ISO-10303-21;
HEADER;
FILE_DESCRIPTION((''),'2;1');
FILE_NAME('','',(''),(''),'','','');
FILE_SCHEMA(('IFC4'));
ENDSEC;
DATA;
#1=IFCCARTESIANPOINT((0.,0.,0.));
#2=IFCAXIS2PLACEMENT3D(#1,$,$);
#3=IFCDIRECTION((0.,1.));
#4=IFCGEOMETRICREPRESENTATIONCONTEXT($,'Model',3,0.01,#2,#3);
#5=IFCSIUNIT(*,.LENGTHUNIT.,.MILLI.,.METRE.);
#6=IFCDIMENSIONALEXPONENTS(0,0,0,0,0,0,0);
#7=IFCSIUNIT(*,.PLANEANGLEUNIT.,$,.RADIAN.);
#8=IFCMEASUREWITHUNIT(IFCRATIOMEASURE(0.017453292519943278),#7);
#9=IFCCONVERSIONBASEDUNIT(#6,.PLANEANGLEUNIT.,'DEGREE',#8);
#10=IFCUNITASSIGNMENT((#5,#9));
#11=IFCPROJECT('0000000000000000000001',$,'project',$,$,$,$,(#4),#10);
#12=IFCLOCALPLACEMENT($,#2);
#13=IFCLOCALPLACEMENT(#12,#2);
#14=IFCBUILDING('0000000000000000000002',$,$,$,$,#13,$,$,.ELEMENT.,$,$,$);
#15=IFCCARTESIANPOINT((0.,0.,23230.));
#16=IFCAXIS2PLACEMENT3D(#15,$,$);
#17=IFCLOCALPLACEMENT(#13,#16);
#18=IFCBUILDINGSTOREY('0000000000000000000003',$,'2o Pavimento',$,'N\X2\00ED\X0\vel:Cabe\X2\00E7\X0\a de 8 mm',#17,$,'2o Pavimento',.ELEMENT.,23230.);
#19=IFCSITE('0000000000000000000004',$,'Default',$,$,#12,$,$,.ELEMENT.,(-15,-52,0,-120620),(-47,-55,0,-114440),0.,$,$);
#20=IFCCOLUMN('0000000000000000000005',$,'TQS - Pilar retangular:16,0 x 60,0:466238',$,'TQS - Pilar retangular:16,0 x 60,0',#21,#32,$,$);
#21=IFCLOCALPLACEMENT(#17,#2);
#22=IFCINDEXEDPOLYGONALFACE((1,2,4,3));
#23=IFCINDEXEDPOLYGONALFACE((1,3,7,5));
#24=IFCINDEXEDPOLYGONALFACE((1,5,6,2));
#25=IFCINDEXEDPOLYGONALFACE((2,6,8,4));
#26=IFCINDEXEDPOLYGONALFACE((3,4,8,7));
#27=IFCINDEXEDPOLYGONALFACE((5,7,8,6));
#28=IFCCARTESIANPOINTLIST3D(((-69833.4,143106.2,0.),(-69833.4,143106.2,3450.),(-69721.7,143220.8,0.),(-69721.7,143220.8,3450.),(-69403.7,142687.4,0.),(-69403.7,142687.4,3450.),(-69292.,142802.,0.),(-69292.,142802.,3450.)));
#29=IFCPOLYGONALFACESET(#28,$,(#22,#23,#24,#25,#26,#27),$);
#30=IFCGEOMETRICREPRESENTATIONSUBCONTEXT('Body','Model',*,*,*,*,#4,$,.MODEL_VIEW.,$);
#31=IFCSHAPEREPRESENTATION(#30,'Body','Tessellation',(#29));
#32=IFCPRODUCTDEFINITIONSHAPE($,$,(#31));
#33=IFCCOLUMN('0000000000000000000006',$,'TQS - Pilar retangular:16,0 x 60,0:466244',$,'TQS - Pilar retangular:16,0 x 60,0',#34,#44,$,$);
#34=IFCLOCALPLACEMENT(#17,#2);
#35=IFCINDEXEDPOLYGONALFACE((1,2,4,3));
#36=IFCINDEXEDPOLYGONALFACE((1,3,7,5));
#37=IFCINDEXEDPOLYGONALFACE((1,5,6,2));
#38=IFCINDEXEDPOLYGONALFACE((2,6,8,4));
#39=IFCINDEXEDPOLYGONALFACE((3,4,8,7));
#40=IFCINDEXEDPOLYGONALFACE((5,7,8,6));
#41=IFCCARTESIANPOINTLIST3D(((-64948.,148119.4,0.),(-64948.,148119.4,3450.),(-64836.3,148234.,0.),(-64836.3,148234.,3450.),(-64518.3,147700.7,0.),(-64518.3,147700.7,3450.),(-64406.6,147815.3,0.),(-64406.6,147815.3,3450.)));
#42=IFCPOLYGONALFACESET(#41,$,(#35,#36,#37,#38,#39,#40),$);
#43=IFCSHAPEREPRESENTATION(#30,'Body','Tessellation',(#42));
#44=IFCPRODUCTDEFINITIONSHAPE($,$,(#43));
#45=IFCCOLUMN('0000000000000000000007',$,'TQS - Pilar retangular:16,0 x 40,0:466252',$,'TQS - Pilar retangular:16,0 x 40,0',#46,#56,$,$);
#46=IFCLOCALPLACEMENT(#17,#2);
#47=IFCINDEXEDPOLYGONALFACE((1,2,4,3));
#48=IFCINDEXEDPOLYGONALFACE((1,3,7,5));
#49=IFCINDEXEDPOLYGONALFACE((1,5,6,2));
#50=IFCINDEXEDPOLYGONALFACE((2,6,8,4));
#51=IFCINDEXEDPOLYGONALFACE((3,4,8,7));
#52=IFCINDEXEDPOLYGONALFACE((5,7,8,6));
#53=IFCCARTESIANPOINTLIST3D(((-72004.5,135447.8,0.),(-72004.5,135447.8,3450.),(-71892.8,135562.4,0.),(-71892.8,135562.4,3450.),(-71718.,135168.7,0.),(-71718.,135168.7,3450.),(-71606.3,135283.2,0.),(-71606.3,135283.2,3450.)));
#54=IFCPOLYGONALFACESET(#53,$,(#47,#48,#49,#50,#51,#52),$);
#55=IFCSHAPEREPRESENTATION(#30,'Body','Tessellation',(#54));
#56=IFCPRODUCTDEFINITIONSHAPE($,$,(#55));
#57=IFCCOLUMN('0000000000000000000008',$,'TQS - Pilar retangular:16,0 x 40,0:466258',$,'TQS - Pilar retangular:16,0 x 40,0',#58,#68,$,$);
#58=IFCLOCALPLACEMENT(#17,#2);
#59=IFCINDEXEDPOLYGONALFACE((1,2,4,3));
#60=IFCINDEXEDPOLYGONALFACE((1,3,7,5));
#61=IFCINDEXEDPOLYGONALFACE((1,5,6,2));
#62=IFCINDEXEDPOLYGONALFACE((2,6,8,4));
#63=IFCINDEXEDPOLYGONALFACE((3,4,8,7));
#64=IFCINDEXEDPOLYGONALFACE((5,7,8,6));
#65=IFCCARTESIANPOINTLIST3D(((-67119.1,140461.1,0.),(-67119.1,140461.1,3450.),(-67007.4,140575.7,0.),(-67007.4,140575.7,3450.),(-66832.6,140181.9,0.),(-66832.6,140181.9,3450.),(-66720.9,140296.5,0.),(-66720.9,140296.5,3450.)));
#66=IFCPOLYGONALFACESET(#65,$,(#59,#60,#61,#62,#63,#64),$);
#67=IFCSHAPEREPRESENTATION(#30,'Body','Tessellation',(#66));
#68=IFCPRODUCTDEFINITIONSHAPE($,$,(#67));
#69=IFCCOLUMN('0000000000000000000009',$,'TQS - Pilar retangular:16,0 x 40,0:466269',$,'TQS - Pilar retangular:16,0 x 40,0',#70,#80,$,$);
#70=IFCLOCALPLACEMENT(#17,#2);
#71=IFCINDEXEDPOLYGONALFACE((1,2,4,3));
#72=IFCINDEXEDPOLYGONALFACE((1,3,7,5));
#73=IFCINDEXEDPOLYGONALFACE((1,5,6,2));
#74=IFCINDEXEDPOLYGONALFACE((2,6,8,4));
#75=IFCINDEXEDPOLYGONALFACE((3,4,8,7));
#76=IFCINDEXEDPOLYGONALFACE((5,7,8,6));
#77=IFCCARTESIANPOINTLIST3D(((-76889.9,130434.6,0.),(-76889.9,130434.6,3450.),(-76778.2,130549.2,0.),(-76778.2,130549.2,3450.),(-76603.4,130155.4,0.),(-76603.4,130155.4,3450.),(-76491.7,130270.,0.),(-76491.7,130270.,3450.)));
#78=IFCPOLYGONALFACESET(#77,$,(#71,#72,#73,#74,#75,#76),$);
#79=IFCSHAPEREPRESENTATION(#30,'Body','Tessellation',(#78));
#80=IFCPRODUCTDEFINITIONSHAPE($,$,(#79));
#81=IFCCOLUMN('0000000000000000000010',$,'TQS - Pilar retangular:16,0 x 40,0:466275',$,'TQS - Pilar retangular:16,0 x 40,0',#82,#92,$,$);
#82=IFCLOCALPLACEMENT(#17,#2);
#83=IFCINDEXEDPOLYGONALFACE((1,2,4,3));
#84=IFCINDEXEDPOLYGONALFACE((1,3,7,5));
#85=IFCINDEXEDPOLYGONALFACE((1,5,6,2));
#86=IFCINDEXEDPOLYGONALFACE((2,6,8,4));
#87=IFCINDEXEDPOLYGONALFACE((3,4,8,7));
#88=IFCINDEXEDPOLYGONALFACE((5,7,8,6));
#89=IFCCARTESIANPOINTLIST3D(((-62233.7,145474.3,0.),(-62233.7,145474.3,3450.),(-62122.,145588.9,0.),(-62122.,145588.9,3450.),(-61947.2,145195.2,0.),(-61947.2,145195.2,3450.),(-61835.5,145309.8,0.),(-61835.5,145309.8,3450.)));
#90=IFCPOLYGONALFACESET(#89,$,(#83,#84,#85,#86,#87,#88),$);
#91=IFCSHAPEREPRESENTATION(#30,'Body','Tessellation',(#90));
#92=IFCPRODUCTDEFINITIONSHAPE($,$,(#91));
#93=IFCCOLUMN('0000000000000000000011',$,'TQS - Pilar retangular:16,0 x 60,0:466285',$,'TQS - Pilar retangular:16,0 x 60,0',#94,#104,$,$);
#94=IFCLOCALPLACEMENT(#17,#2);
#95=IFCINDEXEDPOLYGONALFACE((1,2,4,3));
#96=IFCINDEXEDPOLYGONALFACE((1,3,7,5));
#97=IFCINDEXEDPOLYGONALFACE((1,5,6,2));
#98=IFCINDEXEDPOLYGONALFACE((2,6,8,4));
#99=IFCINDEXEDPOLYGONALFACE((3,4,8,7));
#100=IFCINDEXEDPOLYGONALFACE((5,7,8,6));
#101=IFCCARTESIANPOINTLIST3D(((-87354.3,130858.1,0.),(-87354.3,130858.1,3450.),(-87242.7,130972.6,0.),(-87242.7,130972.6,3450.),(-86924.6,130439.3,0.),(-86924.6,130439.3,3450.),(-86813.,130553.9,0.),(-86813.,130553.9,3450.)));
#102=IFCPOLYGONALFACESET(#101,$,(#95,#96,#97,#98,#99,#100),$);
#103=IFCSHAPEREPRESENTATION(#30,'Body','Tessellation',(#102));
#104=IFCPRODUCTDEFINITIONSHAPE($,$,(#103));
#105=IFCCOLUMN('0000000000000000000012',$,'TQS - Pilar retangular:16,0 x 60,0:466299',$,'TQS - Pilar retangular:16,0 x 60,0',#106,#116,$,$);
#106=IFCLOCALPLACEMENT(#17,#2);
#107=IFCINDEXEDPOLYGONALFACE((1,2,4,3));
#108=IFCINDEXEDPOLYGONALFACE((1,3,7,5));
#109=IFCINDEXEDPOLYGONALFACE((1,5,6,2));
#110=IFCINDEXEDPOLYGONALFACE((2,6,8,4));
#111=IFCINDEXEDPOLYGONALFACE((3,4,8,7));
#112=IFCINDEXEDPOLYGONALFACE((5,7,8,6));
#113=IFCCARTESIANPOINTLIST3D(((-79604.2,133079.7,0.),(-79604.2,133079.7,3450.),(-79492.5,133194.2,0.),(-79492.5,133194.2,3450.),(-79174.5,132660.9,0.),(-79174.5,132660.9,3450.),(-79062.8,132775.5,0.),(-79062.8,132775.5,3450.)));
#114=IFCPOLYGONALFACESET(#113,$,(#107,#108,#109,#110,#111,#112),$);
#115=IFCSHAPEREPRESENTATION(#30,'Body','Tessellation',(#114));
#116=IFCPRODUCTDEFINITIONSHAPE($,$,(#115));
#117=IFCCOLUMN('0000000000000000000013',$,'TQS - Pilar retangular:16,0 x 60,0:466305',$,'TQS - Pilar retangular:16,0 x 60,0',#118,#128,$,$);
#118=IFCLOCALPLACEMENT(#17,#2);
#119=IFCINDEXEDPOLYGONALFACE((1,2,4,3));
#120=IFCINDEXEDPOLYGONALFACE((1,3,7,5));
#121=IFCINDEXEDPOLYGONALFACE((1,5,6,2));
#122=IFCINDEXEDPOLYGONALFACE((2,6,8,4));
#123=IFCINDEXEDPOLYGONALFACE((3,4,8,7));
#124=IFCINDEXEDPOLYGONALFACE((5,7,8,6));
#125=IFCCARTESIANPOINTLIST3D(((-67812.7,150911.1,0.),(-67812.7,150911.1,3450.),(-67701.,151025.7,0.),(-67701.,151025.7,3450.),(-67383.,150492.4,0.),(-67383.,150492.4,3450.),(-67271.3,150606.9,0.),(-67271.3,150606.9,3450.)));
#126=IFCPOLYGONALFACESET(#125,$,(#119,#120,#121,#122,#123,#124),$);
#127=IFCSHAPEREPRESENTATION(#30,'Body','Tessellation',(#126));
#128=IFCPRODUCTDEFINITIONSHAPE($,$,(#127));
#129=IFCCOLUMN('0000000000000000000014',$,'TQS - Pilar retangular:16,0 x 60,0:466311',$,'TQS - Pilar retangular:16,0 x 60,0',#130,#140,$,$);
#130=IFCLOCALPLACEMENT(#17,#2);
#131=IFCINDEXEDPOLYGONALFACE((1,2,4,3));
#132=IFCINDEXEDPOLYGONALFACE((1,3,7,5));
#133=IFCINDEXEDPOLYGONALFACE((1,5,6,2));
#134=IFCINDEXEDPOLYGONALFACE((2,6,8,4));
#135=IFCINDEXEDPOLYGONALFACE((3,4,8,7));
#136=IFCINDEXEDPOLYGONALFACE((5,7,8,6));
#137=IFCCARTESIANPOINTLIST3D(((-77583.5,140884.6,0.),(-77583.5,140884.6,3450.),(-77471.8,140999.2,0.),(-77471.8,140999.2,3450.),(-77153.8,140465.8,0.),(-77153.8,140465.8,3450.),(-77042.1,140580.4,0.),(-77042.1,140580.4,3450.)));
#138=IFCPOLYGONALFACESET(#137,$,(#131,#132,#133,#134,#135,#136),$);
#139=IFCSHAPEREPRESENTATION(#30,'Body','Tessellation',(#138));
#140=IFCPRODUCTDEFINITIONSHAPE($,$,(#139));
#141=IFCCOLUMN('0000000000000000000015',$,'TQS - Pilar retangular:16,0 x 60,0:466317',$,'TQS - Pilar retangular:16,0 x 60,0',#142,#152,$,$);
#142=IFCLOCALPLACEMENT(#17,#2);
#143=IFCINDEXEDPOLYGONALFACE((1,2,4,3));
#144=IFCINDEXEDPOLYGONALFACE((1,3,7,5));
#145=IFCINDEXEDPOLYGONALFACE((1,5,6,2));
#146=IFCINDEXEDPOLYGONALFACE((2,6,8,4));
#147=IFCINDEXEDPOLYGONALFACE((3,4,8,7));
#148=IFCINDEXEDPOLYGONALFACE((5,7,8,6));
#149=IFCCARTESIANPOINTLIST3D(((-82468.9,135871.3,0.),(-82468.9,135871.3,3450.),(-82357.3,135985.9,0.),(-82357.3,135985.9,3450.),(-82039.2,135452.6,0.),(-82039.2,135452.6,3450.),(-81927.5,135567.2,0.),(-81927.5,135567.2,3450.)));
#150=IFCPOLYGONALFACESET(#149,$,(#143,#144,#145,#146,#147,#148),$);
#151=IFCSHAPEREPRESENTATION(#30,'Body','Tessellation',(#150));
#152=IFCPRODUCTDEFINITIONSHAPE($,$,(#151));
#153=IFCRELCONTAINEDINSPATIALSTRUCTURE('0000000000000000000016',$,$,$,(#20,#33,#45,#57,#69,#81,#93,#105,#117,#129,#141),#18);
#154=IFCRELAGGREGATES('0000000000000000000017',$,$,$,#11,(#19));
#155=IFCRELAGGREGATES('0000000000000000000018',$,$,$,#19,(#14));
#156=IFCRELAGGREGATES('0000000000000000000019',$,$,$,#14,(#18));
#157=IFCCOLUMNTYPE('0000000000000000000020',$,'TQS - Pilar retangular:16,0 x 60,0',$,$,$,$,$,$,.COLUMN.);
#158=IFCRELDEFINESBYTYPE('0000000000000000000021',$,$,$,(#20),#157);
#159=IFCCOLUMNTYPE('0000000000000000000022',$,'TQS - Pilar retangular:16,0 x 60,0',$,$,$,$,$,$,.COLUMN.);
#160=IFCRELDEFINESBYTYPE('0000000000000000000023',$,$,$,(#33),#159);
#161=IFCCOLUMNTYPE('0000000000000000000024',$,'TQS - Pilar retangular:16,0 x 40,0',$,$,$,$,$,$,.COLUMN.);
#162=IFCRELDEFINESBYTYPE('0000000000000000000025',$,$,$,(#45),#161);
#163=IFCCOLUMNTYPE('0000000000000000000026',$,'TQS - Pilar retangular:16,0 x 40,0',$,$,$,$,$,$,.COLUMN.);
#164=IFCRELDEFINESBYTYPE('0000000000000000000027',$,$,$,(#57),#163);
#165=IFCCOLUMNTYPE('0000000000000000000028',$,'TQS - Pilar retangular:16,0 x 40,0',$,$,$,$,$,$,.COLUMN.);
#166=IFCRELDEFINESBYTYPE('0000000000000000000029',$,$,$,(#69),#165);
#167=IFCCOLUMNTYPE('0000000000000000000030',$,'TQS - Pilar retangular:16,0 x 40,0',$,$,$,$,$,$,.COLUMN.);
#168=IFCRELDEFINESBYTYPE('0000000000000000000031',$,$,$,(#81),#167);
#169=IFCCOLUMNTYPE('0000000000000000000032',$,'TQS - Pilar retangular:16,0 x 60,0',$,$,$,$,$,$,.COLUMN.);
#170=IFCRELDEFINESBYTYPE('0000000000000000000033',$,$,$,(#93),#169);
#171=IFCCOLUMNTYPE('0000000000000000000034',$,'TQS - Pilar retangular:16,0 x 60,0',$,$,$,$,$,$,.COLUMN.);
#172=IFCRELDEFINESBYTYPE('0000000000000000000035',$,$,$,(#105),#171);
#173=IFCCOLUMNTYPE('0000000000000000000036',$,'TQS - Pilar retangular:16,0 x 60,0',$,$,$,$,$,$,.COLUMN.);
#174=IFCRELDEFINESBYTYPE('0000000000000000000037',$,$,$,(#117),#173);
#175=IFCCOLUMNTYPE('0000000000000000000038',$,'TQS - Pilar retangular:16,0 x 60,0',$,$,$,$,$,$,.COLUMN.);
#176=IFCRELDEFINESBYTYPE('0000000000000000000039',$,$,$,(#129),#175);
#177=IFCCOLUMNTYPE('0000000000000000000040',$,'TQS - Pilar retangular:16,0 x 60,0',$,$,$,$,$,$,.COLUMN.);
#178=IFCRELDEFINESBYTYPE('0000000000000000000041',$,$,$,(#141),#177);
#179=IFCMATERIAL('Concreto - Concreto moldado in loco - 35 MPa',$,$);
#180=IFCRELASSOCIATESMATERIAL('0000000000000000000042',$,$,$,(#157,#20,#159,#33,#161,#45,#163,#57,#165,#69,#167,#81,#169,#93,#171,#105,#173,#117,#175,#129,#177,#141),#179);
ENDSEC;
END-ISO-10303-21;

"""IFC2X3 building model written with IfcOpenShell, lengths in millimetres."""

from ifc_helpers import new_model, entity, si_unit, converted_unit, direction, frame, frame_2d, origin, place, context, subcontext, project, spatial, rectangle, extrude, source, transform, mapped, material, type_object, type_shapes, element, save


model = new_model("IFC2X3")

# Units and contexts
model_context = context("Model", 3, precision=0.01, world=origin(), true_north=direction((0.0, 1.0)))
body_context = subcontext(model_context, "Body", "Model", "MODEL_VIEW")
ifc_project = project(units=[si_unit("LENGTHUNIT", "METRE", prefix="MILLI"), converted_unit("PLANEANGLEUNIT", "DEGREE", entity("IfcRatioMeasure", 0.017453292519943278), si_unit("PLANEANGLEUNIT", "RADIAN"), dimensions=[0, 0, 0, 0, 0, 0, 0])], contexts=[model_context])

# Site, building, storey
site_placement = place(None, origin())
site = spatial("IfcSite", under=ifc_project, at=site_placement, Name="Default", CompositionType="ELEMENT", RefLatitude=(-15, -52, 0, -120620), RefLongitude=(-47, -55, 0, -114440), RefElevation=0.0)
building_placement = place(site_placement, origin())
building = spatial("IfcBuilding", under=site, at=building_placement, CompositionType="ELEMENT")
storey_placement = place(building_placement, frame((0.0, 0.0, 23230.0)))
storey = spatial("IfcBuildingStorey", under=building, at=storey_placement, Name="2o Pavimento", ObjectType="Nível:Cabeça de 8 mm", LongName="2o Pavimento", CompositionType="ELEMENT", Elevation=23230.0)

# Columns
ifc_material = material(Name="Concreto - Concreto moldado in loco - 35 MPa")
column_type_1 = type_object("IfcColumnType", Name="TQS - Pilar retangular:16,0 x 60,0", PredefinedType="COLUMN", material=ifc_material)
shared_shape_1 = source(origin(), body_context, "Body", "SweptSolid", [
    extrude(rectangle(XDim=600.0, YDim=160.0, at=frame_2d((0.0, 0.0), x_axis=(1.0, 0.0))), frame((-69562.7, 142954.1, 23230.0), z_axis=(0.0, 0.0, 1.0), x_axis=(-0.71618, 0.697915, 0.0)), (0.0, 0.0, 1.0), 3450.0),
])
type_shapes(column_type_1, [shared_shape_1])
column_1_placement = place(storey_placement, frame((0.0, 0.0, -23230.0)))
element("IfcColumn", 1, at=column_1_placement, inside=storey, type_object=column_type_1, material=ifc_material, Name="TQS - Pilar retangular:16,0 x 60,0:466238", ObjectType="TQS - Pilar retangular:16,0 x 60,0", context=body_context, shape_type="MappedRepresentation", body=[
    mapped(shared_shape_1, transform((0.0, 0.0, 0.0), scale=1.0)),
])
column_type_2 = type_object("IfcColumnType", Name="TQS - Pilar retangular:16,0 x 60,0", PredefinedType="COLUMN", material=ifc_material)
shared_shape_2 = source(origin(), body_context, "Body", "SweptSolid", [
    extrude(rectangle(XDim=600.0, YDim=160.0, at=frame_2d((0.0, 0.0), x_axis=(1.0, 0.0))), frame((-64677.3, 147967.4, 23230.0), z_axis=(0.0, 0.0, 1.0), x_axis=(-0.71618, 0.697915, 0.0)), (0.0, 0.0, 1.0), 3450.0),
])
type_shapes(column_type_2, [shared_shape_2])
column_2_placement = place(storey_placement, frame((0.0, 0.0, -23230.0)))
element("IfcColumn", 2, at=column_2_placement, inside=storey, type_object=column_type_2, material=ifc_material, Name="TQS - Pilar retangular:16,0 x 60,0:466244", ObjectType="TQS - Pilar retangular:16,0 x 60,0", context=body_context, shape_type="MappedRepresentation", body=[
    mapped(shared_shape_2, transform((0.0, 0.0, 0.0), scale=1.0)),
])
column_type_3 = type_object("IfcColumnType", Name="TQS - Pilar retangular:16,0 x 40,0", PredefinedType="COLUMN", material=ifc_material)
shared_shape_3 = source(origin(), body_context, "Body", "SweptSolid", [
    extrude(rectangle(XDim=400.0, YDim=160.0, at=frame_2d((0.0, 0.0), x_axis=(1.0, 0.0))), frame((-71805.4, 135365.5, 23230.0), z_axis=(0.0, 0.0, 1.0), x_axis=(-0.71618, 0.697915, 0.0)), (0.0, 0.0, 1.0), 3450.0),
])
type_shapes(column_type_3, [shared_shape_3])
column_3_placement = place(storey_placement, frame((0.0, 0.0, -23230.0)))
element("IfcColumn", 3, at=column_3_placement, inside=storey, type_object=column_type_3, material=ifc_material, Name="TQS - Pilar retangular:16,0 x 40,0:466252", ObjectType="TQS - Pilar retangular:16,0 x 40,0", context=body_context, shape_type="MappedRepresentation", body=[
    mapped(shared_shape_3, transform((0.0, 0.0, 0.0), scale=1.0)),
])
column_type_4 = type_object("IfcColumnType", Name="TQS - Pilar retangular:16,0 x 40,0", PredefinedType="COLUMN", material=ifc_material)
shared_shape_4 = source(origin(), body_context, "Body", "SweptSolid", [
    extrude(rectangle(XDim=400.0, YDim=160.0, at=frame_2d((0.0, 0.0), x_axis=(1.0, 0.0))), frame((-66920.0, 140378.8, 23230.0), z_axis=(0.0, 0.0, 1.0), x_axis=(-0.71618, 0.697915, 0.0)), (0.0, 0.0, 1.0), 3450.0),
])
type_shapes(column_type_4, [shared_shape_4])
column_4_placement = place(storey_placement, frame((0.0, 0.0, -23230.0)))
element("IfcColumn", 4, at=column_4_placement, inside=storey, type_object=column_type_4, material=ifc_material, Name="TQS - Pilar retangular:16,0 x 40,0:466258", ObjectType="TQS - Pilar retangular:16,0 x 40,0", context=body_context, shape_type="MappedRepresentation", body=[
    mapped(shared_shape_4, transform((0.0, 0.0, 0.0), scale=1.0)),
])
column_type_5 = type_object("IfcColumnType", Name="TQS - Pilar retangular:16,0 x 40,0", PredefinedType="COLUMN", material=ifc_material)
shared_shape_5 = source(origin(), body_context, "Body", "SweptSolid", [
    extrude(rectangle(XDim=400.0, YDim=160.0, at=frame_2d((0.0, 0.0), x_axis=(1.0, 0.0))), frame((-76690.8, 130352.3, 23230.0), z_axis=(0.0, 0.0, 1.0), x_axis=(-0.71618, 0.697915, 0.0)), (0.0, 0.0, 1.0), 3450.0),
])
type_shapes(column_type_5, [shared_shape_5])
column_5_placement = place(storey_placement, frame((0.0, 0.0, -23230.0)))
element("IfcColumn", 5, at=column_5_placement, inside=storey, type_object=column_type_5, material=ifc_material, Name="TQS - Pilar retangular:16,0 x 40,0:466269", ObjectType="TQS - Pilar retangular:16,0 x 40,0", context=body_context, shape_type="MappedRepresentation", body=[
    mapped(shared_shape_5, transform((0.0, 0.0, 0.0), scale=1.0)),
])
column_type_6 = type_object("IfcColumnType", Name="TQS - Pilar retangular:16,0 x 40,0", PredefinedType="COLUMN", material=ifc_material)
shared_shape_6 = source(origin(), body_context, "Body", "SweptSolid", [
    extrude(rectangle(XDim=400.0, YDim=160.0, at=frame_2d((0.0, 0.0), x_axis=(1.0, 0.0))), frame((-62034.6, 145392.1, 23230.0), z_axis=(0.0, 0.0, 1.0), x_axis=(-0.71618, 0.697915, 0.0)), (0.0, 0.0, 1.0), 3450.0),
])
type_shapes(column_type_6, [shared_shape_6])
column_6_placement = place(storey_placement, frame((0.0, 0.0, -23230.0)))
element("IfcColumn", 6, at=column_6_placement, inside=storey, type_object=column_type_6, material=ifc_material, Name="TQS - Pilar retangular:16,0 x 40,0:466275", ObjectType="TQS - Pilar retangular:16,0 x 40,0", context=body_context, shape_type="MappedRepresentation", body=[
    mapped(shared_shape_6, transform((0.0, 0.0, 0.0), scale=1.0)),
])
column_type_7 = type_object("IfcColumnType", Name="TQS - Pilar retangular:16,0 x 60,0", PredefinedType="COLUMN", material=ifc_material)
shared_shape_7 = source(origin(), body_context, "Body", "SweptSolid", [
    extrude(rectangle(XDim=600.0, YDim=160.0, at=frame_2d((0.0, 0.0), x_axis=(1.0, 0.0))), frame((-87083.6, 130706.0, 23230.0), z_axis=(0.0, 0.0, 1.0), x_axis=(-0.71618, 0.697915, 0.0)), (0.0, 0.0, 1.0), 3450.0),
])
type_shapes(column_type_7, [shared_shape_7])
column_7_placement = place(storey_placement, frame((0.0, 0.0, -23230.0)))
element("IfcColumn", 7, at=column_7_placement, inside=storey, type_object=column_type_7, material=ifc_material, Name="TQS - Pilar retangular:16,0 x 60,0:466285", ObjectType="TQS - Pilar retangular:16,0 x 60,0", context=body_context, shape_type="MappedRepresentation", body=[
    mapped(shared_shape_7, transform((0.0, 0.0, 0.0), scale=1.0)),
])
column_type_8 = type_object("IfcColumnType", Name="TQS - Pilar retangular:16,0 x 60,0", PredefinedType="COLUMN", material=ifc_material)
shared_shape_8 = source(origin(), body_context, "Body", "SweptSolid", [
    extrude(rectangle(XDim=600.0, YDim=160.0, at=frame_2d((0.0, 0.0), x_axis=(1.0, 0.0))), frame((-79333.5, 132927.6, 23230.0), z_axis=(0.0, 0.0, 1.0), x_axis=(-0.71618, 0.697915, 0.0)), (0.0, 0.0, 1.0), 3450.0),
])
type_shapes(column_type_8, [shared_shape_8])
column_8_placement = place(storey_placement, frame((0.0, 0.0, -23230.0)))
element("IfcColumn", 8, at=column_8_placement, inside=storey, type_object=column_type_8, material=ifc_material, Name="TQS - Pilar retangular:16,0 x 60,0:466299", ObjectType="TQS - Pilar retangular:16,0 x 60,0", context=body_context, shape_type="MappedRepresentation", body=[
    mapped(shared_shape_8, transform((0.0, 0.0, 0.0), scale=1.0)),
])
column_type_9 = type_object("IfcColumnType", Name="TQS - Pilar retangular:16,0 x 60,0", PredefinedType="COLUMN", material=ifc_material)
shared_shape_9 = source(origin(), body_context, "Body", "SweptSolid", [
    extrude(rectangle(XDim=600.0, YDim=160.0, at=frame_2d((0.0, 0.0), x_axis=(1.0, 0.0))), frame((-67542.0, 150759.0, 23230.0), z_axis=(0.0, 0.0, 1.0), x_axis=(-0.71618, 0.697915, 0.0)), (0.0, 0.0, 1.0), 3450.0),
])
type_shapes(column_type_9, [shared_shape_9])
column_9_placement = place(storey_placement, frame((0.0, 0.0, -23230.0)))
element("IfcColumn", 9, at=column_9_placement, inside=storey, type_object=column_type_9, material=ifc_material, Name="TQS - Pilar retangular:16,0 x 60,0:466305", ObjectType="TQS - Pilar retangular:16,0 x 60,0", context=body_context, shape_type="MappedRepresentation", body=[
    mapped(shared_shape_9, transform((0.0, 0.0, 0.0), scale=1.0)),
])
column_type_10 = type_object("IfcColumnType", Name="TQS - Pilar retangular:16,0 x 60,0", PredefinedType="COLUMN", material=ifc_material)
shared_shape_10 = source(origin(), body_context, "Body", "SweptSolid", [
    extrude(rectangle(XDim=600.0, YDim=160.0, at=frame_2d((0.0, 0.0), x_axis=(1.0, 0.0))), frame((-77312.8, 140732.5, 23230.0), z_axis=(0.0, 0.0, 1.0), x_axis=(-0.71618, 0.697915, 0.0)), (0.0, 0.0, 1.0), 3450.0),
])
type_shapes(column_type_10, [shared_shape_10])
column_10_placement = place(storey_placement, frame((0.0, 0.0, -23230.0)))
element("IfcColumn", 10, at=column_10_placement, inside=storey, type_object=column_type_10, material=ifc_material, Name="TQS - Pilar retangular:16,0 x 60,0:466311", ObjectType="TQS - Pilar retangular:16,0 x 60,0", context=body_context, shape_type="MappedRepresentation", body=[
    mapped(shared_shape_10, transform((0.0, 0.0, 0.0), scale=1.0)),
])
column_type_11 = type_object("IfcColumnType", Name="TQS - Pilar retangular:16,0 x 60,0", PredefinedType="COLUMN", material=ifc_material)
shared_shape_11 = source(origin(), body_context, "Body", "SweptSolid", [
    extrude(rectangle(XDim=600.0, YDim=160.0, at=frame_2d((0.0, 0.0), x_axis=(1.0, 0.0))), frame((-82198.2, 135719.2, 23230.0), z_axis=(0.0, 0.0, 1.0), x_axis=(-0.71618, 0.697915, 0.0)), (0.0, 0.0, 1.0), 3450.0),
])
type_shapes(column_type_11, [shared_shape_11])
column_11_placement = place(storey_placement, frame((0.0, 0.0, -23230.0)))
element("IfcColumn", 11, at=column_11_placement, inside=storey, type_object=column_type_11, material=ifc_material, Name="TQS - Pilar retangular:16,0 x 60,0:466317", ObjectType="TQS - Pilar retangular:16,0 x 60,0", context=body_context, shape_type="MappedRepresentation", body=[
    mapped(shared_shape_11, transform((0.0, 0.0, 0.0), scale=1.0)),
])

save(model, "model.ifc")
